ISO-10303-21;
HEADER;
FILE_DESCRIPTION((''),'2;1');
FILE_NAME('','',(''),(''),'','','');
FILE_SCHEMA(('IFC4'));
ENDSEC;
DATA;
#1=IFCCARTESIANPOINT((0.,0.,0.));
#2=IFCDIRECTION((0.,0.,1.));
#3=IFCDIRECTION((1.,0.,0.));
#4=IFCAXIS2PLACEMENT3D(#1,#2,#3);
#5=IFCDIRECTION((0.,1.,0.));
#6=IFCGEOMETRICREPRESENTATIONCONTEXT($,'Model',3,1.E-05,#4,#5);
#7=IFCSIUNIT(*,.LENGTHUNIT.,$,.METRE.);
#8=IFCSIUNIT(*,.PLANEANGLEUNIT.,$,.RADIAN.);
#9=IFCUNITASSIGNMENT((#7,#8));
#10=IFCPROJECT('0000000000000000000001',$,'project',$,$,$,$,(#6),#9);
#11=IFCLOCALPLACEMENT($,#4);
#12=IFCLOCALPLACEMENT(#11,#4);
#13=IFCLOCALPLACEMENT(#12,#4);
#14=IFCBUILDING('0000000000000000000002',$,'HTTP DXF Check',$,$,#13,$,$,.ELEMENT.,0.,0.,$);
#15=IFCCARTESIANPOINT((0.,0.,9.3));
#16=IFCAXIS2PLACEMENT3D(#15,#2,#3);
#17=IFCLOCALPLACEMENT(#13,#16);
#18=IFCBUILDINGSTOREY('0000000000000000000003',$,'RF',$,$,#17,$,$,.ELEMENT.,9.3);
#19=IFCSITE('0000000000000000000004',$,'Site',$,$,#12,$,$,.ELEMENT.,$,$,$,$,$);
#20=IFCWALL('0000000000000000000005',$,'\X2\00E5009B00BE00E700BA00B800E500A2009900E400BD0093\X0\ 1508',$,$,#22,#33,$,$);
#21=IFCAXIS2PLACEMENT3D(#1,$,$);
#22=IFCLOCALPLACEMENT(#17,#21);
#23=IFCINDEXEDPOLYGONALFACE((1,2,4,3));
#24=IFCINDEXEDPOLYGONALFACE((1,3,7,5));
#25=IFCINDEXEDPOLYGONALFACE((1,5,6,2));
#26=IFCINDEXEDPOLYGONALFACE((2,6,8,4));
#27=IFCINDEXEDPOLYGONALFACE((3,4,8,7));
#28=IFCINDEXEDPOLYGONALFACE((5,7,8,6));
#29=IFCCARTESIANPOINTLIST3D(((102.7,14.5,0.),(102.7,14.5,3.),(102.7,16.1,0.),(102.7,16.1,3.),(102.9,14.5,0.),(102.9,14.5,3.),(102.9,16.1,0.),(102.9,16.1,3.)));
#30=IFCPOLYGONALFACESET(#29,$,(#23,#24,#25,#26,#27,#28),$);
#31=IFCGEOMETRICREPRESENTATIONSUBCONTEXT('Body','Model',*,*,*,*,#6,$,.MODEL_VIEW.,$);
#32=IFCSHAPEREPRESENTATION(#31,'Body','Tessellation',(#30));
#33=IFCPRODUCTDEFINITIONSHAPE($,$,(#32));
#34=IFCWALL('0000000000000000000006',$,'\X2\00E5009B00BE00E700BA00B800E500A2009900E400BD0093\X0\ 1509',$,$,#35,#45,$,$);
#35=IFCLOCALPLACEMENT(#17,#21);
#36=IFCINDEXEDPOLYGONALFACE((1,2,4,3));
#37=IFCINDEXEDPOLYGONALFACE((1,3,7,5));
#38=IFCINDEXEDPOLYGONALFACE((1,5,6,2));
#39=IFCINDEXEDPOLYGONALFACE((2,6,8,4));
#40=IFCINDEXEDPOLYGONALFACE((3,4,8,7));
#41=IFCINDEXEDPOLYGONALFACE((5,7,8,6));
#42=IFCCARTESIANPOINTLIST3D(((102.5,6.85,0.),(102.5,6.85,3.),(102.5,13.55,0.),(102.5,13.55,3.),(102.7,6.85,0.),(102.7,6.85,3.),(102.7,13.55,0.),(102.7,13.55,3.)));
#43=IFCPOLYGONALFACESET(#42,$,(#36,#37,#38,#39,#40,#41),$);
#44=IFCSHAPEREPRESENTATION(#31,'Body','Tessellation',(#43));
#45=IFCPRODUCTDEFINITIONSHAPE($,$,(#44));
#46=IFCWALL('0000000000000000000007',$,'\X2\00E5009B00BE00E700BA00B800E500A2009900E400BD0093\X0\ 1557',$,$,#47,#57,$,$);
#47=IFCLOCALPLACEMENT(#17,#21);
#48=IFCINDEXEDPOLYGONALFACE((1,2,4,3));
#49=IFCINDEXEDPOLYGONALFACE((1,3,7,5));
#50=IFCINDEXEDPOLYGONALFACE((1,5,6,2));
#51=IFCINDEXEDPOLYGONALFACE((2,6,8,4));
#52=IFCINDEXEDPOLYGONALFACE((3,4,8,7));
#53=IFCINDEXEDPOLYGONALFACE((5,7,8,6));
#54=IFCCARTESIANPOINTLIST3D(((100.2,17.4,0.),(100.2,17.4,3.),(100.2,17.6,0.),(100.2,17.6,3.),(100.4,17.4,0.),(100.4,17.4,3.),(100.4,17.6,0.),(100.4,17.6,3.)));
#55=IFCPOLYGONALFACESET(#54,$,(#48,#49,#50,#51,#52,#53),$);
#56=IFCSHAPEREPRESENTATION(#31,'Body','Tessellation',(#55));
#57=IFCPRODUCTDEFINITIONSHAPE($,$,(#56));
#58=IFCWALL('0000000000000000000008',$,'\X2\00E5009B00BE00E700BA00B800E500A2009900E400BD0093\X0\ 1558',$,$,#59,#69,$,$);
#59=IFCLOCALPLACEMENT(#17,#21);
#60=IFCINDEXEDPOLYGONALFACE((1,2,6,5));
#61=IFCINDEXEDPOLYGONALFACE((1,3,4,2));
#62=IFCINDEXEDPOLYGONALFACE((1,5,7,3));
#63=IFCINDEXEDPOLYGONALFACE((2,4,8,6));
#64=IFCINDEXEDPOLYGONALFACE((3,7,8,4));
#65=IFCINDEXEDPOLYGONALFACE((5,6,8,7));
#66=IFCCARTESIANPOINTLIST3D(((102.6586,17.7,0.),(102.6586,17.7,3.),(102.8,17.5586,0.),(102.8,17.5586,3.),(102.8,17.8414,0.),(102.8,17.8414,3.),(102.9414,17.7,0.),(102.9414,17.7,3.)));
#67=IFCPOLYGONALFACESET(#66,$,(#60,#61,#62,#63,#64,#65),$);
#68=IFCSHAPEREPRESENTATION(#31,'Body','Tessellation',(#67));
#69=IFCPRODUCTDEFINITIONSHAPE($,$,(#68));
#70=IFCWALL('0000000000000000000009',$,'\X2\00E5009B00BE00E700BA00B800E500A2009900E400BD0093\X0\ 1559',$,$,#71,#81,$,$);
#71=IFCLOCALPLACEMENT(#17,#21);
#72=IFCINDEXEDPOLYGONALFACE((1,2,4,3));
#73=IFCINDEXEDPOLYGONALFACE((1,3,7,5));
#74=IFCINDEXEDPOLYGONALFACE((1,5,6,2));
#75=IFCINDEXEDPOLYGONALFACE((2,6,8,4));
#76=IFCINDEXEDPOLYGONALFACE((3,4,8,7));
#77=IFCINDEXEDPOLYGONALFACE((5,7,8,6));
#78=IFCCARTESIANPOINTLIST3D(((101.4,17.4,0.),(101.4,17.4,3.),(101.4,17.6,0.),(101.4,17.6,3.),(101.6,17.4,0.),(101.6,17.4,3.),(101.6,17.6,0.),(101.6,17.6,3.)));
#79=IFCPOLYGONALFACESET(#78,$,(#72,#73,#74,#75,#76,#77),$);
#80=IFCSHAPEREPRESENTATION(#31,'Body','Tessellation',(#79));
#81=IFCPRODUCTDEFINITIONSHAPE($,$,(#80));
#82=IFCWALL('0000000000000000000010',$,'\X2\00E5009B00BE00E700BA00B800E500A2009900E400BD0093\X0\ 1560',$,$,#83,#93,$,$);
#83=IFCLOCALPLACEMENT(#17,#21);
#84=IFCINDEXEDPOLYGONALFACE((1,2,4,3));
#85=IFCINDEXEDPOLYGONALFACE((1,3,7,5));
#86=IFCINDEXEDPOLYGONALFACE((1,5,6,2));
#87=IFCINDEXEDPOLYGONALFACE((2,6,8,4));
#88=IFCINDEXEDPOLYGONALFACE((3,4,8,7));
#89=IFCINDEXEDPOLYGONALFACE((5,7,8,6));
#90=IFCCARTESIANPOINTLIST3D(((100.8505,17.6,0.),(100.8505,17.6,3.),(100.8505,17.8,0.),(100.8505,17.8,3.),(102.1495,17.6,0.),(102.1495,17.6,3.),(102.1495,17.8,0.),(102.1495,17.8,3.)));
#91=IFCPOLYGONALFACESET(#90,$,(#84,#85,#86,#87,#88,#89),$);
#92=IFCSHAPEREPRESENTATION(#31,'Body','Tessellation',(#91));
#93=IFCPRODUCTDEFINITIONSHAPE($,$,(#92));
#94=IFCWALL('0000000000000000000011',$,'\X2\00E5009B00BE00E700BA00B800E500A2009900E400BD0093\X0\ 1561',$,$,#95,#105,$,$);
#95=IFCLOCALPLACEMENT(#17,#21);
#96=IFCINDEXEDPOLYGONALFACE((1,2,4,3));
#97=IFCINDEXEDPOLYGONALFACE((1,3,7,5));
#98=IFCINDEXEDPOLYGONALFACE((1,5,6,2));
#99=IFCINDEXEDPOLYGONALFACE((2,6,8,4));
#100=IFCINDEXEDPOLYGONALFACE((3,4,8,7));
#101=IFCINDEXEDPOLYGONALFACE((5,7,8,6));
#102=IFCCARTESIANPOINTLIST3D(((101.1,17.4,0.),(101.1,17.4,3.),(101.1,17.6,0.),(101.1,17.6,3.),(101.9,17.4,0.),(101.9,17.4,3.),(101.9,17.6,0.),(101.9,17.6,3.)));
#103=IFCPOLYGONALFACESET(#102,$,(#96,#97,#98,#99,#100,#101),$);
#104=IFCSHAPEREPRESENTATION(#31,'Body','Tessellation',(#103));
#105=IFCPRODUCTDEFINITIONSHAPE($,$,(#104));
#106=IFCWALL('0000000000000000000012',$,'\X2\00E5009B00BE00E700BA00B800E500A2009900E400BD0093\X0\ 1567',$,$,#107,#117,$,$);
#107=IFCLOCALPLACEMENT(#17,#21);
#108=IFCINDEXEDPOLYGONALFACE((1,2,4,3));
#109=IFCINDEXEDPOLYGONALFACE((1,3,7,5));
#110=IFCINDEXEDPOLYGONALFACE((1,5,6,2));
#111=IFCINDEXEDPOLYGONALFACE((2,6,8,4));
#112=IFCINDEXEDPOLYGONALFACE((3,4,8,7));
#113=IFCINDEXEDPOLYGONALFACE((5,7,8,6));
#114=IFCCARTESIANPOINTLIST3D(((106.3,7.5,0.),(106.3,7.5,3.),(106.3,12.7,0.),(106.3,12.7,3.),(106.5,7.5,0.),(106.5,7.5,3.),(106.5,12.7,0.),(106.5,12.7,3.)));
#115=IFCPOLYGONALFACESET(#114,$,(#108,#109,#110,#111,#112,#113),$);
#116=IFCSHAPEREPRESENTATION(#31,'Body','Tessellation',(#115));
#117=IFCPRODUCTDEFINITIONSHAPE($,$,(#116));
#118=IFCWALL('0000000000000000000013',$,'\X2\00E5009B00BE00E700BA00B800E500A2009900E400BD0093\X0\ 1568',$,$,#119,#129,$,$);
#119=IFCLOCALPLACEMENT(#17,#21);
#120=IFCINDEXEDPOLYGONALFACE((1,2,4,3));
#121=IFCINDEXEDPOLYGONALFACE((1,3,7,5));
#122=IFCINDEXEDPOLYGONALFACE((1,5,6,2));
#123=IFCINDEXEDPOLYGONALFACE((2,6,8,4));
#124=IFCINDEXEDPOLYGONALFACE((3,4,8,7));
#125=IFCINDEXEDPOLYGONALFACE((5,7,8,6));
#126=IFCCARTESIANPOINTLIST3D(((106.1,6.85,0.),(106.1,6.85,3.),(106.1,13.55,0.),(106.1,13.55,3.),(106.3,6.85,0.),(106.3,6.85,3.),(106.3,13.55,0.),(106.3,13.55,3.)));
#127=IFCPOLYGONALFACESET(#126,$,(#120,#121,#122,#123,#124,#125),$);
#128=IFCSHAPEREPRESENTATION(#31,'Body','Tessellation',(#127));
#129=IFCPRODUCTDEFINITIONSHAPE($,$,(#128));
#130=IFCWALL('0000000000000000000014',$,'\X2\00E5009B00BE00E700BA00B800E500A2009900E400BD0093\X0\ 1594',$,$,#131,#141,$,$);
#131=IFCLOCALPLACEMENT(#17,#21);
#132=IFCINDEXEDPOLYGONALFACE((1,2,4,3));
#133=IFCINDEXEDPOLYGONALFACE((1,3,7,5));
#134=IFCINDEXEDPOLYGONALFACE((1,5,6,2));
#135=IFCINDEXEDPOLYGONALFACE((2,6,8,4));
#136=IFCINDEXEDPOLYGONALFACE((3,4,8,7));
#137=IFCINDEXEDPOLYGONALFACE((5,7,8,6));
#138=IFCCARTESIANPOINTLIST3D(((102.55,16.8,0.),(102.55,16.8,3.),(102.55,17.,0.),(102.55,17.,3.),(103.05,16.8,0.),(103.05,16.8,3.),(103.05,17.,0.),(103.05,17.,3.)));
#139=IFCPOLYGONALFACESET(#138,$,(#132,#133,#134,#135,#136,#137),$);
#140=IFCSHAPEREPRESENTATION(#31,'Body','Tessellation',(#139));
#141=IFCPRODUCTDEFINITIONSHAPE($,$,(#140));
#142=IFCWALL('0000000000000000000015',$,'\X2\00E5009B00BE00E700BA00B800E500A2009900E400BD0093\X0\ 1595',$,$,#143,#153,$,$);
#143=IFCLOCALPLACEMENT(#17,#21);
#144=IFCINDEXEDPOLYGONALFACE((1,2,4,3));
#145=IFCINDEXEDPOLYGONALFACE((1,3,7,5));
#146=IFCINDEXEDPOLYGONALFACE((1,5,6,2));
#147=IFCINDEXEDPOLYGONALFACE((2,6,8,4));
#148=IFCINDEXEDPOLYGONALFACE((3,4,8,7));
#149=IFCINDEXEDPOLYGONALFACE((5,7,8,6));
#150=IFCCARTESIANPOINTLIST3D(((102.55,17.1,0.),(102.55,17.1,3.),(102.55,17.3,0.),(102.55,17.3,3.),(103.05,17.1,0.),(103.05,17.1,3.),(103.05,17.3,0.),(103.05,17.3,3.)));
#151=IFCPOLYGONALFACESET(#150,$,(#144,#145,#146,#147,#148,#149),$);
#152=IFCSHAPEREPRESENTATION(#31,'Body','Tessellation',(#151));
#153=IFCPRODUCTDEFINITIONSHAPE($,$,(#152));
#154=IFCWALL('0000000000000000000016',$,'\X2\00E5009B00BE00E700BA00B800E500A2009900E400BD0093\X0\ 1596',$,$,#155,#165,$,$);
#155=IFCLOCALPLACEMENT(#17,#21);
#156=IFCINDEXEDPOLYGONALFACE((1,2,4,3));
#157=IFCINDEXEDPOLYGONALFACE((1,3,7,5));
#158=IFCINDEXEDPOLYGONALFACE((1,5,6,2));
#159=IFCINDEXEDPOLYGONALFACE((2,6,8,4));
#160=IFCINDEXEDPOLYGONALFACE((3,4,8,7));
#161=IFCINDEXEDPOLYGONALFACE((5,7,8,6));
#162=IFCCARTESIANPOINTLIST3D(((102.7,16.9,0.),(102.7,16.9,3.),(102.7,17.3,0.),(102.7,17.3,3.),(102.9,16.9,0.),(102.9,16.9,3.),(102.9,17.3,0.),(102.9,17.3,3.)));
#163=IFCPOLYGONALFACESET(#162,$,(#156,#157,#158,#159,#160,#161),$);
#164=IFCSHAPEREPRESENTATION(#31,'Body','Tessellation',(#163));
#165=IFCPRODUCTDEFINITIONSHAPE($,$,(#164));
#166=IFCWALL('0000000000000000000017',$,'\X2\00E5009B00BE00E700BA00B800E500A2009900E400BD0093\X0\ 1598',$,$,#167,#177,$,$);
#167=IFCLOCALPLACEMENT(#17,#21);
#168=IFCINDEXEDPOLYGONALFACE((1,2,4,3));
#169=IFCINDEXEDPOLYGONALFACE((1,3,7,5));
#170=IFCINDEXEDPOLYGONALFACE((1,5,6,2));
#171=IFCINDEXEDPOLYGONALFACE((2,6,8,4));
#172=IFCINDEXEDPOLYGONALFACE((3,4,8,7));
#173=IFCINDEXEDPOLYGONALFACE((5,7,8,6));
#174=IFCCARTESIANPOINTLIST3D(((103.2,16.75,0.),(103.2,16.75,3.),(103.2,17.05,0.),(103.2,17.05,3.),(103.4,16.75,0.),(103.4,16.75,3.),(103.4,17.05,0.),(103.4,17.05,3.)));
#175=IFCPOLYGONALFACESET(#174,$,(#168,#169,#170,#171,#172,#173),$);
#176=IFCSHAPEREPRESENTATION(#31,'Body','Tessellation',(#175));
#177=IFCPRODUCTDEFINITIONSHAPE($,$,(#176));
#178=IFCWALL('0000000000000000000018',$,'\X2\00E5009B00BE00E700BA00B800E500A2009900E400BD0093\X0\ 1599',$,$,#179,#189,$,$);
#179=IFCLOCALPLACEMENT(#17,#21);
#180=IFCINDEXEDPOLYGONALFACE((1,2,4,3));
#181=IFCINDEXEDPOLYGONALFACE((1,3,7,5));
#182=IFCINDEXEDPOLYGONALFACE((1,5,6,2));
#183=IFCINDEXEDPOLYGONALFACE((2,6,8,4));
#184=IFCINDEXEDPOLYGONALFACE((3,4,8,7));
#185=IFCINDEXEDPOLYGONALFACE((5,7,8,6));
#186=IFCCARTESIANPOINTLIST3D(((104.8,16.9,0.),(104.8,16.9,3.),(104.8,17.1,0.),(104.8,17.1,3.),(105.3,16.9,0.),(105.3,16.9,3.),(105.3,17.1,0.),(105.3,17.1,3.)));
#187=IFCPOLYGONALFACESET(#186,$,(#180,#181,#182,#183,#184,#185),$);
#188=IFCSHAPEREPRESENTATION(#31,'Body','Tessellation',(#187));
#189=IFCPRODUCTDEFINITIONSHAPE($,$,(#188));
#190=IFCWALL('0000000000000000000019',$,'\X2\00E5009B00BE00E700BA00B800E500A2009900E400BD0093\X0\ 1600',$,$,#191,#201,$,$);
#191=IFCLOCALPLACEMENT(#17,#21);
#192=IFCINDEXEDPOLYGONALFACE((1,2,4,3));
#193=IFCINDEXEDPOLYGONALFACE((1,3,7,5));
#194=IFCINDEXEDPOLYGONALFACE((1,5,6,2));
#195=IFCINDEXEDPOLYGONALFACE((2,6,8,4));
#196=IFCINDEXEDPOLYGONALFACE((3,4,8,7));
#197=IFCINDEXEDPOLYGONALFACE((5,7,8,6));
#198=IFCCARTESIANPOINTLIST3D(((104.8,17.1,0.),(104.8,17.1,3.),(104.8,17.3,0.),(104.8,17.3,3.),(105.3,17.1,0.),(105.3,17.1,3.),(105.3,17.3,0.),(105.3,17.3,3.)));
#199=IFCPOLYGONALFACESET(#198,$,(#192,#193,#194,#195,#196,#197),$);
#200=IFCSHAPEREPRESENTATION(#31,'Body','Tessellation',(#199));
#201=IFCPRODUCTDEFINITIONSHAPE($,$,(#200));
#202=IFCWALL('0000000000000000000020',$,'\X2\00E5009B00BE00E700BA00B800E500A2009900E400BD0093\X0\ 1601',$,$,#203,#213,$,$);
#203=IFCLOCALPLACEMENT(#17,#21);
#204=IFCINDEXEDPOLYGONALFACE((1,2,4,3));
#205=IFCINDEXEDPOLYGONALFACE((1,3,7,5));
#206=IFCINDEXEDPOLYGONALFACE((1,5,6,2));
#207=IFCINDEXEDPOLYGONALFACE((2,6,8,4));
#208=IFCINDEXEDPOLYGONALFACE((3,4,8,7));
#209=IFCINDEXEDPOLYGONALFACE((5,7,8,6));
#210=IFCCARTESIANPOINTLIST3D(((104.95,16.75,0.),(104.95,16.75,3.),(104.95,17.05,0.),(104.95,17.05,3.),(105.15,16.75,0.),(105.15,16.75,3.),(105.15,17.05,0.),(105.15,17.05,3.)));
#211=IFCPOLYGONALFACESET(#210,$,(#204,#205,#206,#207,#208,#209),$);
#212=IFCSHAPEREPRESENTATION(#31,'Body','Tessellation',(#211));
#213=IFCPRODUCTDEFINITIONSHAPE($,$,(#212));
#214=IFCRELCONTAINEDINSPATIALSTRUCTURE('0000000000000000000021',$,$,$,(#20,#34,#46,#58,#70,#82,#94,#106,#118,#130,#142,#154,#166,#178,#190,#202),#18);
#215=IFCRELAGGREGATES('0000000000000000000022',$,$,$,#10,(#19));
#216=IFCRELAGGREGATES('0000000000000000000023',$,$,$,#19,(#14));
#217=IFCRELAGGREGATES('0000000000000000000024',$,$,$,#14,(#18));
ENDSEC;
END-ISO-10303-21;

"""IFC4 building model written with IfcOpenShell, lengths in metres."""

from ifc_helpers import new_model, si_unit, direction, frame, frame_2d, origin_with_axes, place, context, subcontext, project, spatial, rectangle, extrude, element, save


model = new_model("IFC4")

# Units and contexts
model_context = context("Model", 3, precision=1e-05, world=origin_with_axes(), true_north=direction((0.0, 1.0, 0.0)))
body_context = subcontext(model_context, "Body", "Model", "MODEL_VIEW")
ifc_project = project(units=[si_unit("LENGTHUNIT", "METRE"), si_unit("PLANEANGLEUNIT", "RADIAN")], contexts=[model_context])

# Site, building, storey
placement = place(None, origin_with_axes())
site_placement = place(placement, origin_with_axes())
site = spatial("IfcSite", under=ifc_project, at=site_placement, Name="Site", CompositionType="ELEMENT")
building_placement = place(site_placement, origin_with_axes())
building = spatial("IfcBuilding", under=site, at=building_placement, Name="HTTP DXF Check", CompositionType="ELEMENT", ElevationOfRefHeight=0.0, ElevationOfTerrain=0.0)
storey_placement = place(building_placement, frame((0.0, 0.0, 9.3), z_axis=(0.0, 0.0, 1.0), x_axis=(1.0, 0.0, 0.0)))
storey = spatial("IfcBuildingStorey", under=building, at=storey_placement, Name="RF", CompositionType="ELEMENT", Elevation=9.3)

# Walls
wall_1_placement = place(storey_placement, frame((102.8, 15.3, 0.0), z_axis=(0.0, 0.0, 1.0), x_axis=(0.0, 1.0, 0.0)))
element("IfcWall", 1, at=wall_1_placement, inside=storey, Name="å\u009b¾çº¸å¢\u0099ä½\u0093 1508", context=body_context, shape_type="SweptSolid", body=[
    extrude(rectangle(XDim=1.6, YDim=0.2, at=frame_2d((0.0, 0.0), x_axis=(1.0, 0.0, 0.0))), frame((0.0, 0.0, 0.0), z_axis=(0.0, 0.0, 1.0)), (0.0, 0.0, 1.0), 3.0),
])
wall_2_placement = place(storey_placement, frame((102.6, 10.2, 0.0), z_axis=(0.0, 0.0, 1.0), x_axis=(0.0, 1.0, 0.0)))
element("IfcWall", 2, at=wall_2_placement, inside=storey, Name="å\u009b¾çº¸å¢\u0099ä½\u0093 1509", context=body_context, shape_type="SweptSolid", body=[
    extrude(rectangle(XDim=6.7, YDim=0.2, at=frame_2d((0.0, 0.0), x_axis=(1.0, 0.0, 0.0))), frame((0.0, 0.0, 0.0), z_axis=(0.0, 0.0, 1.0)), (0.0, 0.0, 1.0), 3.0),
])
for number, where, z_axis, x_axis, name in (
    (3, (100.3, 17.5, 0.0), (0.0, 0.0, 1.0), (0.0, 1.0, 0.0), "å\u009b¾çº¸å¢\u0099ä½\u0093 1557"),
    (4, (102.8, 17.7, 0.0), (0.0, 0.0, 1.0), (0.707107, -0.707107, 0.0), "å\u009b¾çº¸å¢\u0099ä½\u0093 1558"),
    (5, (101.5, 17.5, 0.0), (0.0, 0.0, 1.0), (0.0, 1.0, 0.0), "å\u009b¾çº¸å¢\u0099ä½\u0093 1559"),
):
    element("IfcWall", number, at=place(storey_placement, frame(where, z_axis=z_axis, x_axis=x_axis)), inside=storey, Name=name, context=body_context, shape_type="SweptSolid", body=[
        extrude(rectangle(XDim=0.2, YDim=0.2, at=frame_2d((0.0, 0.0), x_axis=(1.0, 0.0, 0.0))), frame((0.0, 0.0, 0.0), z_axis=(0.0, 0.0, 1.0)), (0.0, 0.0, 1.0), 3.0),
    ])
wall_3_placement = place(storey_placement, frame((101.5, 17.7, 0.0), z_axis=(0.0, 0.0, 1.0), x_axis=(1.0, 0.0, 0.0)))
element("IfcWall", 6, at=wall_3_placement, inside=storey, Name="å\u009b¾çº¸å¢\u0099ä½\u0093 1560", context=body_context, shape_type="SweptSolid", body=[
    extrude(rectangle(XDim=1.299, YDim=0.2, at=frame_2d((0.0, 0.0), x_axis=(1.0, 0.0, 0.0))), frame((0.0, 0.0, 0.0), z_axis=(0.0, 0.0, 1.0)), (0.0, 0.0, 1.0), 3.0),
])
wall_4_placement = place(storey_placement, frame((101.5, 17.5, 0.0), z_axis=(0.0, 0.0, 1.0), x_axis=(1.0, 0.0, 0.0)))
element("IfcWall", 7, at=wall_4_placement, inside=storey, Name="å\u009b¾çº¸å¢\u0099ä½\u0093 1561", context=body_context, shape_type="SweptSolid", body=[
    extrude(rectangle(XDim=0.8, YDim=0.2, at=frame_2d((0.0, 0.0), x_axis=(1.0, 0.0, 0.0))), frame((0.0, 0.0, 0.0), z_axis=(0.0, 0.0, 1.0)), (0.0, 0.0, 1.0), 3.0),
])
wall_5_placement = place(storey_placement, frame((106.4, 10.1, 0.0), z_axis=(0.0, 0.0, 1.0), x_axis=(0.0, 1.0, 0.0)))
element("IfcWall", 8, at=wall_5_placement, inside=storey, Name="å\u009b¾çº¸å¢\u0099ä½\u0093 1567", context=body_context, shape_type="SweptSolid", body=[
    extrude(rectangle(XDim=5.2, YDim=0.2, at=frame_2d((0.0, 0.0), x_axis=(1.0, 0.0, 0.0))), frame((0.0, 0.0, 0.0), z_axis=(0.0, 0.0, 1.0)), (0.0, 0.0, 1.0), 3.0),
])
wall_6_placement = place(storey_placement, frame((106.2, 10.2, 0.0), z_axis=(0.0, 0.0, 1.0), x_axis=(0.0, 1.0, 0.0)))
element("IfcWall", 9, at=wall_6_placement, inside=storey, Name="å\u009b¾çº¸å¢\u0099ä½\u0093 1568", context=body_context, shape_type="SweptSolid", body=[
    extrude(rectangle(XDim=6.7, YDim=0.2, at=frame_2d((0.0, 0.0), x_axis=(1.0, 0.0, 0.0))), frame((0.0, 0.0, 0.0), z_axis=(0.0, 0.0, 1.0)), (0.0, 0.0, 1.0), 3.0),
])
for number, where, z_axis, x_axis, name in (
    (10, (102.8, 16.9, 0.0), (0.0, 0.0, 1.0), (1.0, 0.0, 0.0), "å\u009b¾çº¸å¢\u0099ä½\u0093 1594"),
    (11, (102.8, 17.2, 0.0), (0.0, 0.0, 1.0), (1.0, 0.0, 0.0), "å\u009b¾çº¸å¢\u0099ä½\u0093 1595"),
):
    element("IfcWall", number, at=place(storey_placement, frame(where, z_axis=z_axis, x_axis=x_axis)), inside=storey, Name=name, context=body_context, shape_type="SweptSolid", body=[
        extrude(rectangle(XDim=0.5, YDim=0.2, at=frame_2d((0.0, 0.0), x_axis=(1.0, 0.0, 0.0))), frame((0.0, 0.0, 0.0), z_axis=(0.0, 0.0, 1.0)), (0.0, 0.0, 1.0), 3.0),
    ])
wall_7_placement = place(storey_placement, frame((102.8, 17.1, 0.0), z_axis=(0.0, 0.0, 1.0), x_axis=(0.0, 1.0, 0.0)))
element("IfcWall", 12, at=wall_7_placement, inside=storey, Name="å\u009b¾çº¸å¢\u0099ä½\u0093 1596", context=body_context, shape_type="SweptSolid", body=[
    extrude(rectangle(XDim=0.4, YDim=0.2, at=frame_2d((0.0, 0.0), x_axis=(1.0, 0.0, 0.0))), frame((0.0, 0.0, 0.0), z_axis=(0.0, 0.0, 1.0)), (0.0, 0.0, 1.0), 3.0),
])
wall_8_placement = place(storey_placement, frame((103.3, 16.9, 0.0), z_axis=(0.0, 0.0, 1.0), x_axis=(0.0, 1.0, 0.0)))
element("IfcWall", 13, at=wall_8_placement, inside=storey, Name="å\u009b¾çº¸å¢\u0099ä½\u0093 1598", context=body_context, shape_type="SweptSolid", body=[
    extrude(rectangle(XDim=0.3, YDim=0.2, at=frame_2d((0.0, 0.0), x_axis=(1.0, 0.0, 0.0))), frame((0.0, 0.0, 0.0), z_axis=(0.0, 0.0, 1.0)), (0.0, 0.0, 1.0), 3.0),
])
for number, where, z_axis, x_axis, name in (
    (14, (105.05, 17.0, 0.0), (0.0, 0.0, 1.0), (1.0, 0.0, 0.0), "å\u009b¾çº¸å¢\u0099ä½\u0093 1599"),
    (15, (105.05, 17.2, 0.0), (0.0, 0.0, 1.0), (1.0, 0.0, 0.0), "å\u009b¾çº¸å¢\u0099ä½\u0093 1600"),
):
    element("IfcWall", number, at=place(storey_placement, frame(where, z_axis=z_axis, x_axis=x_axis)), inside=storey, Name=name, context=body_context, shape_type="SweptSolid", body=[
        extrude(rectangle(XDim=0.5, YDim=0.2, at=frame_2d((0.0, 0.0), x_axis=(1.0, 0.0, 0.0))), frame((0.0, 0.0, 0.0), z_axis=(0.0, 0.0, 1.0)), (0.0, 0.0, 1.0), 3.0),
    ])
wall_9_placement = place(storey_placement, frame((105.05, 16.9, 0.0), z_axis=(0.0, 0.0, 1.0), x_axis=(0.0, 1.0, 0.0)))
element("IfcWall", 16, at=wall_9_placement, inside=storey, Name="å\u009b¾çº¸å¢\u0099ä½\u0093 1601", context=body_context, shape_type="SweptSolid", body=[
    extrude(rectangle(XDim=0.3, YDim=0.2, at=frame_2d((0.0, 0.0), x_axis=(1.0, 0.0, 0.0))), frame((0.0, 0.0, 0.0), z_axis=(0.0, 0.0, 1.0)), (0.0, 0.0, 1.0), 3.0),
])

save(model, "model.ifc")
